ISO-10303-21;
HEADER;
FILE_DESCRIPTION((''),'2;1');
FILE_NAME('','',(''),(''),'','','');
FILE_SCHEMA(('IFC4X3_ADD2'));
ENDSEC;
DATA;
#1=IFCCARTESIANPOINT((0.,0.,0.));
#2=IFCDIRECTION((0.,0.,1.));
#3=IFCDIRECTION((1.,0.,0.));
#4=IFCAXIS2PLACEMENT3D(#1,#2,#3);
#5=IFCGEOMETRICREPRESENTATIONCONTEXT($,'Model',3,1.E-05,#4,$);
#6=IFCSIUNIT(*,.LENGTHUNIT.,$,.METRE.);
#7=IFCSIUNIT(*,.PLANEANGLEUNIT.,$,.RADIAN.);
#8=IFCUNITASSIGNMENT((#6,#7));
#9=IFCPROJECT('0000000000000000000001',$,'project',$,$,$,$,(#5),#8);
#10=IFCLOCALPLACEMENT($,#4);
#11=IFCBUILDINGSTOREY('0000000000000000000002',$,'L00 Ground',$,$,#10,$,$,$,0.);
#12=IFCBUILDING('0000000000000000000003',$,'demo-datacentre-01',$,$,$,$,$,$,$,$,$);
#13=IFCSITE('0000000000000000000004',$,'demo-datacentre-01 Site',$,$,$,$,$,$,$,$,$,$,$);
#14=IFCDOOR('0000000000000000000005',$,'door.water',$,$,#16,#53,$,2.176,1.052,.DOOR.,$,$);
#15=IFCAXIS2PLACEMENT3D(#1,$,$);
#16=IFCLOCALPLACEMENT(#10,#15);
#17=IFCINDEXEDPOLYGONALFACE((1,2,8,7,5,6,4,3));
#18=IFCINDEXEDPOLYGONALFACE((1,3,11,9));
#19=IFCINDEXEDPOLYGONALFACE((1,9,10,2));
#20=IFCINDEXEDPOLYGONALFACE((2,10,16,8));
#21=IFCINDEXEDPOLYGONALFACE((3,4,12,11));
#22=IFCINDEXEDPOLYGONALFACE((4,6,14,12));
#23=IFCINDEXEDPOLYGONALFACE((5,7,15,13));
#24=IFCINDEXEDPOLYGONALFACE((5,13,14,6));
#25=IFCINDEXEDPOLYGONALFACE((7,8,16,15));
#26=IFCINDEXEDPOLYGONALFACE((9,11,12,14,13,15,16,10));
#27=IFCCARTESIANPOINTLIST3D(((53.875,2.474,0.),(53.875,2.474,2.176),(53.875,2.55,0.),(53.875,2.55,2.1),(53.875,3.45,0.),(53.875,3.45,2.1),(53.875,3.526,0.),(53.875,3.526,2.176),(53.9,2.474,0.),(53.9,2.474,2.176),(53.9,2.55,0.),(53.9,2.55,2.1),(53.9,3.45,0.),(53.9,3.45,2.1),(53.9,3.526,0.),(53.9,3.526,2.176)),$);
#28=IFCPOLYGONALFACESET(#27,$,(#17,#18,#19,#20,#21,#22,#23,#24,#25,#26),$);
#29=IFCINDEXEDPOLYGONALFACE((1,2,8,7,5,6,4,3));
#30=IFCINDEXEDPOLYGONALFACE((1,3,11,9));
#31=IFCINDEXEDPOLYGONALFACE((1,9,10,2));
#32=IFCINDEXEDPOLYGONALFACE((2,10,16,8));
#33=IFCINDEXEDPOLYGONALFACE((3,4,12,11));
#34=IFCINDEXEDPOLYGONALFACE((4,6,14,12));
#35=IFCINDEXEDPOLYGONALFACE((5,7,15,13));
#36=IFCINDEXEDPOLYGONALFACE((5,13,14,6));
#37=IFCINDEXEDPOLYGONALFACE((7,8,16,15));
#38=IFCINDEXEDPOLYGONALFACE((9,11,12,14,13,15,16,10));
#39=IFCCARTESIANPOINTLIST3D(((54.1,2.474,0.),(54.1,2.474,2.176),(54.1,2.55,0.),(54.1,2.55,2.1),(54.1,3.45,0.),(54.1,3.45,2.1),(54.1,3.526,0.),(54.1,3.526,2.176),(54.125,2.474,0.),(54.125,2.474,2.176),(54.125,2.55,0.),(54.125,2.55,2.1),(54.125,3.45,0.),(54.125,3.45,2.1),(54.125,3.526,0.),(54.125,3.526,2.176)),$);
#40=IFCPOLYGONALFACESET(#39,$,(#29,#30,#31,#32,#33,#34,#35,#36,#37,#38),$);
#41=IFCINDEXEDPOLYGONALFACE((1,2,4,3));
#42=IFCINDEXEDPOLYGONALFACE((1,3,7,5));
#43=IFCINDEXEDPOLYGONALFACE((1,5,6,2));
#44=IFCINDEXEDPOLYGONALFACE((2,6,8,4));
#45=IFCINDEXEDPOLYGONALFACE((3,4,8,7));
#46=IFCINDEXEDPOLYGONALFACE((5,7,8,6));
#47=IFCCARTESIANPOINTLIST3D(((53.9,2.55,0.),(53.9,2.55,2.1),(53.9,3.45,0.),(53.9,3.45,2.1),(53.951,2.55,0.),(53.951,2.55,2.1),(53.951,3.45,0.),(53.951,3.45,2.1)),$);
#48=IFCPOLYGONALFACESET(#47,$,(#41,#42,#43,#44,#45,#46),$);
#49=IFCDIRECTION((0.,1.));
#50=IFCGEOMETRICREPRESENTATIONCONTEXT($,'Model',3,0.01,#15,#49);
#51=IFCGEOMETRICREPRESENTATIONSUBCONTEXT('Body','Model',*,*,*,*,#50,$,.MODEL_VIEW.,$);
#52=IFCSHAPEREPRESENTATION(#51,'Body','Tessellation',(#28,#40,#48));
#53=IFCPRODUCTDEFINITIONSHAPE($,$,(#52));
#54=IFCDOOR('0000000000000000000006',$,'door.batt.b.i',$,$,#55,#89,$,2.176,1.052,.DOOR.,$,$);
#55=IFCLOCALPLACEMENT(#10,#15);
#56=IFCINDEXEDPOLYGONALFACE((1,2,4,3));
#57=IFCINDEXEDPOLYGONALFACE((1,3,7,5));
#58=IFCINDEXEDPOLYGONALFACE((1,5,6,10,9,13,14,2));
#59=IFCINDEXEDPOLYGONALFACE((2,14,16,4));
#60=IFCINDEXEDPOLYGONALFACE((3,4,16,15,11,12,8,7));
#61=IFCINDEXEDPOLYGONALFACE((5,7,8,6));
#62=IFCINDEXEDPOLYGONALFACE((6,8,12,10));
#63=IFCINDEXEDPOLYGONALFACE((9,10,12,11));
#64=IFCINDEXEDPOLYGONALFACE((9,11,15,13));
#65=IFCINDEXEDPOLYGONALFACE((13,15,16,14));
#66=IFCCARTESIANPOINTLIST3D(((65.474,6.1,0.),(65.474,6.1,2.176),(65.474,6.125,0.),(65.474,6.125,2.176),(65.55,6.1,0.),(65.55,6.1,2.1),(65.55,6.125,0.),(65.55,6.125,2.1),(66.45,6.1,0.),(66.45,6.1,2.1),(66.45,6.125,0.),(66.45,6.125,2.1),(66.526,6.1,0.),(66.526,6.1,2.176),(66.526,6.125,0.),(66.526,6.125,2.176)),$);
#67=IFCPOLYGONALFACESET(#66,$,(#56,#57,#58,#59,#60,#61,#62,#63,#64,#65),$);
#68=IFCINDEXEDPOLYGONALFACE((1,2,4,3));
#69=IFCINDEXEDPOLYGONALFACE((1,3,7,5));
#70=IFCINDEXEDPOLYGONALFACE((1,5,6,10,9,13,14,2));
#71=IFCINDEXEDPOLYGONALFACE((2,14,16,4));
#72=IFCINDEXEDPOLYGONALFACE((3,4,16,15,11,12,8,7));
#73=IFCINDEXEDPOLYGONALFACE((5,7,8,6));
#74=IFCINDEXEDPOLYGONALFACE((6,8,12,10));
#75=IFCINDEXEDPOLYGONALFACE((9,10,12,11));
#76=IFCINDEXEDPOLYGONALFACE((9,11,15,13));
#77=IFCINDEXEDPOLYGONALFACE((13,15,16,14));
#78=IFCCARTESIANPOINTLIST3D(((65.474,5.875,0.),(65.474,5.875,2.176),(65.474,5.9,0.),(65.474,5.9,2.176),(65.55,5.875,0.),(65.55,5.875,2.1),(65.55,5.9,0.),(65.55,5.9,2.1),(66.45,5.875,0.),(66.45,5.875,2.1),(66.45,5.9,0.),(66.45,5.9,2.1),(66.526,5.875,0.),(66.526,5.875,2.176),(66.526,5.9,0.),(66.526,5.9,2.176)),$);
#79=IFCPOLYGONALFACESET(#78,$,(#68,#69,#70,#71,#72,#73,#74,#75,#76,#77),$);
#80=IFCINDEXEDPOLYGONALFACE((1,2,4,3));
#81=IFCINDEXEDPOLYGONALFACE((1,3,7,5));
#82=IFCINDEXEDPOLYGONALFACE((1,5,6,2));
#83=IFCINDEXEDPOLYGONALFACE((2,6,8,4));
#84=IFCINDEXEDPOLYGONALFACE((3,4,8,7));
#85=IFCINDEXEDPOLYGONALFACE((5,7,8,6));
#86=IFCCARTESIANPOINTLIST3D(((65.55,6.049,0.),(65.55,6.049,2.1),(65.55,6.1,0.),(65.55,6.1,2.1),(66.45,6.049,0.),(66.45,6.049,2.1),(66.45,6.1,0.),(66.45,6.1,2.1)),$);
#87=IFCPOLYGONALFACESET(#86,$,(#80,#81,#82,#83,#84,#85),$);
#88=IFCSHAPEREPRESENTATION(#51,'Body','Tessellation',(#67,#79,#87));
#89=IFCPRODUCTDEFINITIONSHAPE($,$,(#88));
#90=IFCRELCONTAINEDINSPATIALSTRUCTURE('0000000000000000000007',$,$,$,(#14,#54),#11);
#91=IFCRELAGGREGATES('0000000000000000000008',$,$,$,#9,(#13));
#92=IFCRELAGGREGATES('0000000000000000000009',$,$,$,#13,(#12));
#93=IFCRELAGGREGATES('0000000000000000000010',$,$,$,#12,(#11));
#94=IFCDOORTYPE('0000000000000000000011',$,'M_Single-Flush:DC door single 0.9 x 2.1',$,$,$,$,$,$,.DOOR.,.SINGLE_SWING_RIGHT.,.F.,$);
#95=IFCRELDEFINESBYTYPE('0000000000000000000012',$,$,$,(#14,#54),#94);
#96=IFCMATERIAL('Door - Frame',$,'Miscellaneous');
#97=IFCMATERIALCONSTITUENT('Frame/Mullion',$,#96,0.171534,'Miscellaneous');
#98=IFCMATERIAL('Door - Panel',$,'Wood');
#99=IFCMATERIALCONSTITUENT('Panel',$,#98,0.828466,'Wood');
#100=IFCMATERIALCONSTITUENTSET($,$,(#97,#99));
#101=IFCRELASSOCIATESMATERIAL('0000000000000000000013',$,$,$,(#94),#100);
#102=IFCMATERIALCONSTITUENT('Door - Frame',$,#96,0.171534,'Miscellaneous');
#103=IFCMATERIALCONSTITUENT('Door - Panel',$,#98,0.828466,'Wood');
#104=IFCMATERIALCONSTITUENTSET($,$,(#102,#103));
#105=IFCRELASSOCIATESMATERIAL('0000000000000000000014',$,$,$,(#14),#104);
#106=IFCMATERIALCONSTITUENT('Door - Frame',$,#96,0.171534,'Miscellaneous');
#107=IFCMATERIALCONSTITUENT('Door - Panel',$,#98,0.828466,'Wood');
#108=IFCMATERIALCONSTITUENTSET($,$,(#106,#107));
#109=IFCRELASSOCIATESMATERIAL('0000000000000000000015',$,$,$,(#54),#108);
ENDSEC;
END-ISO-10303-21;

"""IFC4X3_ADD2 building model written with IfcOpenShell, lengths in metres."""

from ifc_helpers import new_model, si_unit, direction, frame, frame_2d, origin, origin_with_axes, place, context, subcontext, project, spatial, polyline, rectangle, outline, extrude, source, transform, mapped, material, constituent, constituent_set, type_object, type_shapes, element, save


model = new_model("IFC4X3_ADD2")

# Units and contexts
model_context_1 = context("Model", 3, precision=0.01, world=origin(), true_north=direction((0.0, 1.0)))
model_context_2 = context("Model", 3, precision=1e-05, world=origin_with_axes())
body_context = subcontext(model_context_1, "Body", "Model", "MODEL_VIEW")
ifc_project = project(units=[si_unit("LENGTHUNIT", "METRE"), si_unit("PLANEANGLEUNIT", "RADIAN")], contexts=[model_context_2])

# Site, building, storey
site = spatial("IfcSite", under=ifc_project, Name="demo-datacentre-01 Site")
building = spatial("IfcBuilding", under=site, Name="demo-datacentre-01")
storey_placement = place(None, origin_with_axes())
storey = spatial("IfcBuildingStorey", under=building, at=storey_placement, Name="L00 Ground", Elevation=0.0)

# Shared definitions
placement_1 = place(None, origin())
placement_2 = place(placement_1, origin())
placement_3 = place(placement_2, origin())

# Doors
ifc_material_1 = material(Name="Door - Frame", Category="Miscellaneous")
ifc_material_2 = material(Name="Door - Panel", Category="Wood")
ifc_constituent_1 = constituent(ifc_material_1, Name="Frame/Mullion", Category="Miscellaneous", fraction=0.171534)
ifc_constituent_2 = constituent(ifc_material_2, Name="Panel", Category="Wood", fraction=0.828466)
ifc_constituent_set_1 = constituent_set(constituents=[ifc_constituent_1, ifc_constituent_2])
door_type_1 = type_object("IfcDoorType", Name="M_Single-Flush:DC door single 0.9 x 2.1", OperationType="SINGLE_SWING_RIGHT", ParameterTakesPrecedence=False, PredefinedType="DOOR", material=ifc_constituent_set_1)
shared_shape_1 = source(origin(), body_context, "Body", "SweptSolid", [
    extrude(outline(polyline([(-0.526, -1.107), (0.526, -1.107), (0.526, 1.069), (0.45, 1.069), (0.45, -1.031), (-0.45, -1.031), (-0.45, 1.069), (-0.526, 1.069), (-0.526, -1.107)])), frame((0.45, 0.2, 1.069), z_axis=(0.0, 1.0, 0.0), x_axis=(1.0, 0.0, 0.0)), (0.0, 0.0, 1.0), 0.025),
    extrude(outline(polyline([(-1.107, -0.526), (1.069, -0.526), (1.069, -0.45), (-1.031, -0.45), (-1.031, 0.45), (1.069, 0.45), (1.069, 0.526), (-1.107, 0.526), (-1.107, -0.526)])), frame((0.45, -0.025, 1.069), z_axis=(0.0, 1.0, 0.0), x_axis=(0.0, 0.0, -1.0)), (0.0, 0.0, 1.0), 0.025),
    extrude(rectangle(XDim=0.051, YDim=0.9, at=frame_2d((0.0, 0.0), x_axis=(1.0, 0.0))), frame((0.45, 0.1745, 0.0), z_axis=(0.0, 0.0, 1.0), x_axis=(0.0, 1.0, 0.0)), (0.0, 0.0, 1.0), 2.1),
])
type_shapes(door_type_1, [shared_shape_1])
ifc_constituent_3 = constituent(ifc_material_1, Name="Door - Frame", Category="Miscellaneous", fraction=0.171534)
ifc_constituent_4 = constituent(ifc_material_2, Name="Door - Panel", Category="Wood", fraction=0.828466)
ifc_constituent_set_2 = constituent_set(constituents=[ifc_constituent_3, ifc_constituent_4])
door_1_placement = place(placement_3, frame((54.1, 2.55, 0.0), z_axis=(0.0, 0.0, 1.0), x_axis=(0.0, 1.0, 0.0)))
element("IfcDoor", 1, at=door_1_placement, inside=storey, type_object=door_type_1, material=ifc_constituent_set_2, Name="door.water", OverallHeight=2.176, OverallWidth=1.052, PredefinedType="DOOR", context=body_context, shape_type="MappedRepresentation", body=[
    mapped(shared_shape_1, transform((0.0, 0.0, 0.0), scale=1.0)),
])
ifc_constituent_5 = constituent(ifc_material_1, Name="Door - Frame", Category="Miscellaneous", fraction=0.171534)
ifc_constituent_6 = constituent(ifc_material_2, Name="Door - Panel", Category="Wood", fraction=0.828466)
ifc_constituent_set_3 = constituent_set(constituents=[ifc_constituent_5, ifc_constituent_6])
door_2_placement = place(placement_3, frame((65.55, 5.9, 0.0)))
element("IfcDoor", 2, at=door_2_placement, inside=storey, type_object=door_type_1, material=ifc_constituent_set_3, Name="door.batt.b.i", OverallHeight=2.176, OverallWidth=1.052, PredefinedType="DOOR", context=body_context, shape_type="MappedRepresentation", body=[
    mapped(shared_shape_1, transform((0.0, 0.0, 0.0), scale=1.0)),
])

save(model, "model.ifc")
